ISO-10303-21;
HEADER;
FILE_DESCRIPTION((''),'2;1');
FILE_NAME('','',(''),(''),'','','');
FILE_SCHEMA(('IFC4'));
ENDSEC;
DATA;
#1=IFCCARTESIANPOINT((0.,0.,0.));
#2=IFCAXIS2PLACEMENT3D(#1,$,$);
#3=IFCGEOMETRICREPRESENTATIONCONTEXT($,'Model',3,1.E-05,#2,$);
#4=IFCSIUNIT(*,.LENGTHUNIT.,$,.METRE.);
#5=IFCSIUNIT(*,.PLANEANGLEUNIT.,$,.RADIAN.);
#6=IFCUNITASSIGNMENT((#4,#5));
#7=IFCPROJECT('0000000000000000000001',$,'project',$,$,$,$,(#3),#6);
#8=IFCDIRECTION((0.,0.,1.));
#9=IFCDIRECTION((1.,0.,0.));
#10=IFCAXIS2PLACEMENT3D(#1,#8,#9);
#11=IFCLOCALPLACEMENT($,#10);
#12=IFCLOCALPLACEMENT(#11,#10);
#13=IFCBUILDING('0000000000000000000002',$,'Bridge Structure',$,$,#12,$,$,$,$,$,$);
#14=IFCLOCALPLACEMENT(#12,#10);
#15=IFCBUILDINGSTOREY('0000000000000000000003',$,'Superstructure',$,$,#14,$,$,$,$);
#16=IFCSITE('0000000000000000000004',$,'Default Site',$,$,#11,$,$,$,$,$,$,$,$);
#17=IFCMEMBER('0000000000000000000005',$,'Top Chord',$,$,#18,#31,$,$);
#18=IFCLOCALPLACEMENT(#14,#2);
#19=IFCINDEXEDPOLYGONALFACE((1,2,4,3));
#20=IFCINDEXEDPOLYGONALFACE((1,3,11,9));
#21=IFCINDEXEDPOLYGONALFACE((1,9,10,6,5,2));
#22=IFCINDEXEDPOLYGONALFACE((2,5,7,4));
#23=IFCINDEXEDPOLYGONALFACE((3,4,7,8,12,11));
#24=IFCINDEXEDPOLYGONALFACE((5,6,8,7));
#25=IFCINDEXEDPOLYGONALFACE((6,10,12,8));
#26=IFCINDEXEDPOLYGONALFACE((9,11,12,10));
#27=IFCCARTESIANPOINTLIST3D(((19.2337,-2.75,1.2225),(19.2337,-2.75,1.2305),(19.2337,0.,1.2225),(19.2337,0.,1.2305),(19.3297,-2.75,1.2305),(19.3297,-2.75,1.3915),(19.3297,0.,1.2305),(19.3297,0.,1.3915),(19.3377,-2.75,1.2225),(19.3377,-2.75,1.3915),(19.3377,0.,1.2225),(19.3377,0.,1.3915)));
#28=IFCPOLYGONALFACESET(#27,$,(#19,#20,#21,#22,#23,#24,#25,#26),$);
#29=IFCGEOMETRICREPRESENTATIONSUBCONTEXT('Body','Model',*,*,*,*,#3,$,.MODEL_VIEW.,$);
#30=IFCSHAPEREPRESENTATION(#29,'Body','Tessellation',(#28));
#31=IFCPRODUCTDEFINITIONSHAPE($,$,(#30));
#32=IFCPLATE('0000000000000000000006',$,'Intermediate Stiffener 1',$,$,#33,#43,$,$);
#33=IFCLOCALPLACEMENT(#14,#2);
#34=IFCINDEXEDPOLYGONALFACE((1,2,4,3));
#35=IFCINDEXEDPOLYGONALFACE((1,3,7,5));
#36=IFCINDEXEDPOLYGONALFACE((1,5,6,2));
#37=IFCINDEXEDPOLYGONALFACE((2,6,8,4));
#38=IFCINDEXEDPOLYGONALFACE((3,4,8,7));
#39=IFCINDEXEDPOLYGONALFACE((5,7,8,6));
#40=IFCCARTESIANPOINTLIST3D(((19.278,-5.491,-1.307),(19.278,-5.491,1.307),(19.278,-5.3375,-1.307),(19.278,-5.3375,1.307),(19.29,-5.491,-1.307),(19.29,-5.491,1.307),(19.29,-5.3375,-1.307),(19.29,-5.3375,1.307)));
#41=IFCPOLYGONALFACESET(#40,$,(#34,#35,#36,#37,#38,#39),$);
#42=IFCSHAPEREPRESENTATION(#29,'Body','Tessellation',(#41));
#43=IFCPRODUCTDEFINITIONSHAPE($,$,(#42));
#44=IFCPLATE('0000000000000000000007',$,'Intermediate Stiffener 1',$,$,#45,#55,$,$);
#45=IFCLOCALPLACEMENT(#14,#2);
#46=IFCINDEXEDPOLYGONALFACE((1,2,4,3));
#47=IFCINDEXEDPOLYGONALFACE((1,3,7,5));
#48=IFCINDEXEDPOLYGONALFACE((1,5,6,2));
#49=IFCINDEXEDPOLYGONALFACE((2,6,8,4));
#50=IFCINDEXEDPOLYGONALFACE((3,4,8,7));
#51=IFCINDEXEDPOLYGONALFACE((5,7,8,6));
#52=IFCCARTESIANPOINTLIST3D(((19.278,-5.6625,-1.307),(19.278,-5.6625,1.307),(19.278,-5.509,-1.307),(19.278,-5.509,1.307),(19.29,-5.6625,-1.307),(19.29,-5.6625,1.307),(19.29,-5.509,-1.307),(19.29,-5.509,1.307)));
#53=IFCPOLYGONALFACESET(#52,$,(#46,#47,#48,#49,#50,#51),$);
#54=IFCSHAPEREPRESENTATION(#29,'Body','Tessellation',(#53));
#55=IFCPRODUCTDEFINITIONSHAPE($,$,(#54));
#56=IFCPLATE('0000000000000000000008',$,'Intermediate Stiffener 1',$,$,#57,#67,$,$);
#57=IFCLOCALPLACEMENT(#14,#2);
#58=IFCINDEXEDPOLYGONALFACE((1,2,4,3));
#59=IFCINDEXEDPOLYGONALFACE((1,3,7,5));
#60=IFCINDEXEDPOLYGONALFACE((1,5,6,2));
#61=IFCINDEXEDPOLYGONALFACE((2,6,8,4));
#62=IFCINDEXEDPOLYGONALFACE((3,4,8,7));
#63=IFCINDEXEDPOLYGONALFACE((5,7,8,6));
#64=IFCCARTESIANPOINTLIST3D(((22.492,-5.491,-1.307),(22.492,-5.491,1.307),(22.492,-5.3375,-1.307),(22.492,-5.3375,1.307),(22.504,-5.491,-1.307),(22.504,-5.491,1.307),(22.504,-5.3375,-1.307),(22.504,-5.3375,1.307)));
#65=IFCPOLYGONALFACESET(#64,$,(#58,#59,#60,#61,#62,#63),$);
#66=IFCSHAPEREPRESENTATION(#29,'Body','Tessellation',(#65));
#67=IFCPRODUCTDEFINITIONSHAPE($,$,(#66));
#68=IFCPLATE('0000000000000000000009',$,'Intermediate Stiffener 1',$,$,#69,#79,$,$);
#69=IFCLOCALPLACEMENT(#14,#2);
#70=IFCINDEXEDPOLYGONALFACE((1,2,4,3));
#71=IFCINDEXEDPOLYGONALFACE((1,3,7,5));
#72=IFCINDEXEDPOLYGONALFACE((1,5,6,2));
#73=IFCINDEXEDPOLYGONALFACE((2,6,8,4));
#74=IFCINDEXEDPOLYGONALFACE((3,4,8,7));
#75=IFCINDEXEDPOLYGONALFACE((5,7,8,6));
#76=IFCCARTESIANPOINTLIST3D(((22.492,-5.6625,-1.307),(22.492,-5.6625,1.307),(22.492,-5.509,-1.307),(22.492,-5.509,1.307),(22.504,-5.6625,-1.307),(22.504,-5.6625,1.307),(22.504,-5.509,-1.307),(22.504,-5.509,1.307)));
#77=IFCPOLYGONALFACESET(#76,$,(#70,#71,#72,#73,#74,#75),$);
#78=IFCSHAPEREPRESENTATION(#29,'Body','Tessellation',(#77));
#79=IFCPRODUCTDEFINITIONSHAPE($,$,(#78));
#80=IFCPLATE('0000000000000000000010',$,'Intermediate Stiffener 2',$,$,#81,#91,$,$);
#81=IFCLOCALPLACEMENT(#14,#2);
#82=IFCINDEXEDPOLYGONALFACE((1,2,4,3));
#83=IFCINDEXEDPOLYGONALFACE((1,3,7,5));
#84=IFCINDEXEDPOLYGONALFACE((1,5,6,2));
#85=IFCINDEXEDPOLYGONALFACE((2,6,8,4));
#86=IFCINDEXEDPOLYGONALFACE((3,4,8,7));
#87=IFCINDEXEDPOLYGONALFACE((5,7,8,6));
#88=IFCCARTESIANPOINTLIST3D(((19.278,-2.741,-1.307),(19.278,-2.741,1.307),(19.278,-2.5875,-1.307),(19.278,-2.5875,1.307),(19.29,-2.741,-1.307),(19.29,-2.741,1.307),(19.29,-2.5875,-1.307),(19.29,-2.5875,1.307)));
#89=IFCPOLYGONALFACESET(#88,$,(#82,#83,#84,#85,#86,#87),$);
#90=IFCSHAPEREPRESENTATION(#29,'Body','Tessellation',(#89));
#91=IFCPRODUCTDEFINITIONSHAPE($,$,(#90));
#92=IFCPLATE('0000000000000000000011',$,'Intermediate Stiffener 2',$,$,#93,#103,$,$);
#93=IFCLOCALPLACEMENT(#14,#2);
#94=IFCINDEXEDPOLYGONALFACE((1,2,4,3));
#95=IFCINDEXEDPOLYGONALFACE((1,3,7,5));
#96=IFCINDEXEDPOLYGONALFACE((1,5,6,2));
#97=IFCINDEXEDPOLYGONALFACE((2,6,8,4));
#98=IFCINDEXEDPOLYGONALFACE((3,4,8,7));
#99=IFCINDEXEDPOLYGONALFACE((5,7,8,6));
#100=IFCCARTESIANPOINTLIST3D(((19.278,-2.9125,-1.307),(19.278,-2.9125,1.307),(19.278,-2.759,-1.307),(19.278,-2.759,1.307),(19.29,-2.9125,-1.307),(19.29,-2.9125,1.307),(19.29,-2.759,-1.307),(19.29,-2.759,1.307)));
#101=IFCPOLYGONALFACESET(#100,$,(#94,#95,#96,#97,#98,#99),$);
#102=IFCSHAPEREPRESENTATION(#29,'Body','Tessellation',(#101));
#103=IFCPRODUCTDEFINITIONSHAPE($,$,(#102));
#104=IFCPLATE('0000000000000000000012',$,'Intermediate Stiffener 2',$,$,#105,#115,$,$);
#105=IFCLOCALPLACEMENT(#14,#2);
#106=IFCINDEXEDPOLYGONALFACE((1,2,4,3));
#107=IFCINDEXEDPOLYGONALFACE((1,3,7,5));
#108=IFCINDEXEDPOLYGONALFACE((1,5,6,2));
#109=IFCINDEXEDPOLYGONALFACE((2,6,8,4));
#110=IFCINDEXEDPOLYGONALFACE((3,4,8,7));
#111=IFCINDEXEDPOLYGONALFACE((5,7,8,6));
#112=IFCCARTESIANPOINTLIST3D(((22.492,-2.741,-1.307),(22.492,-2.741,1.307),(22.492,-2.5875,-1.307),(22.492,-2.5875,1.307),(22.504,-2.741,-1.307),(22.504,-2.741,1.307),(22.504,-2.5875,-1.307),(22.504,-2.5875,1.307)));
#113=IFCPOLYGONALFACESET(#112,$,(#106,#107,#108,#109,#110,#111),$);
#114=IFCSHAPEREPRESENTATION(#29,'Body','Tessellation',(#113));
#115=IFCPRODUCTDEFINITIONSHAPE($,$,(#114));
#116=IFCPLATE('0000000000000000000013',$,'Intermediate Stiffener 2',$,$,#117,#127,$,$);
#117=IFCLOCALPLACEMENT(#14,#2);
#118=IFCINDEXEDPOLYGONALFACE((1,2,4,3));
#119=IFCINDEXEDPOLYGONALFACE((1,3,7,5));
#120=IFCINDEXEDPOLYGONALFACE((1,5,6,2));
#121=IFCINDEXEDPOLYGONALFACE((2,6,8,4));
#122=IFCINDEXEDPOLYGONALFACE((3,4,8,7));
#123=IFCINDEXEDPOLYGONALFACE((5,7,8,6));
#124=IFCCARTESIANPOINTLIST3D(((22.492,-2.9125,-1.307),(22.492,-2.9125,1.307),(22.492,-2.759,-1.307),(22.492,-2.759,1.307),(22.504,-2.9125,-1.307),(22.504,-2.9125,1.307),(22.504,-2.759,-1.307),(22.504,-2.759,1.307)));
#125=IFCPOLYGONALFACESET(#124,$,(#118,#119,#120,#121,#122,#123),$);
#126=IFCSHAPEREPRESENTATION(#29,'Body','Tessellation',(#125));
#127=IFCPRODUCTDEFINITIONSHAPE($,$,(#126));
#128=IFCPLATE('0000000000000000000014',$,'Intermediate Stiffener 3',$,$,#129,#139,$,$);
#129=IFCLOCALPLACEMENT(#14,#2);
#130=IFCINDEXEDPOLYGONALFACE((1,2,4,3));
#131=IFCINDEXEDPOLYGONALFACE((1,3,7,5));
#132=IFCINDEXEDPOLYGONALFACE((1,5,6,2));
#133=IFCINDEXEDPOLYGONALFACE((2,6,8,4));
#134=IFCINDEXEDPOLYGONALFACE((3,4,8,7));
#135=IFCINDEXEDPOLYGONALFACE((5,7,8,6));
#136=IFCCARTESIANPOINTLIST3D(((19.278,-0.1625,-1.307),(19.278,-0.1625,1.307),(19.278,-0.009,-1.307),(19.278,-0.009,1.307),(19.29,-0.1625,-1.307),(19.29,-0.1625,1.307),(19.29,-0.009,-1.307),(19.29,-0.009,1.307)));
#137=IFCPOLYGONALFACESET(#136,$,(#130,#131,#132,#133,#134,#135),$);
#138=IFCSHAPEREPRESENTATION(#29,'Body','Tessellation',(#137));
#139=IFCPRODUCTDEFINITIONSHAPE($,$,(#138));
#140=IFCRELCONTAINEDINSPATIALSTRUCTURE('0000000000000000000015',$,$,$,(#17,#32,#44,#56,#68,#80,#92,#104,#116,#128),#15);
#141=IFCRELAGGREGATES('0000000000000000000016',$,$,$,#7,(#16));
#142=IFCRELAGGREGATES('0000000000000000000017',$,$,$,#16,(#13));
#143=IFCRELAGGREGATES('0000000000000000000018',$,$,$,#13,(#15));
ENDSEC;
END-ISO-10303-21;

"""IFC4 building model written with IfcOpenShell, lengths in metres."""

from ifc_helpers import new_model, si_unit, frame, origin, origin_with_axes, origin_2d_with_axis, place, context, subcontext, project, spatial, rectangle, l_section, extrude, element, save


model = new_model("IFC4")

# Units and contexts
model_context = context("Model", 3, precision=1e-05, world=origin())
body_context = subcontext(model_context, "Body", "Model", "MODEL_VIEW")
ifc_project = project(units=[si_unit("LENGTHUNIT", "METRE"), si_unit("PLANEANGLEUNIT", "RADIAN")], contexts=[model_context])

# Site, building, storey
site_placement = place(None, origin_with_axes())
site = spatial("IfcSite", under=ifc_project, at=site_placement, Name="Default Site")
building_placement = place(site_placement, origin_with_axes())
building = spatial("IfcBuilding", under=site, at=building_placement, Name="Bridge Structure")
storey_placement = place(building_placement, origin_with_axes())
storey = spatial("IfcBuildingStorey", under=building, at=storey_placement, Name="Superstructure")

# Member
for number, where, z_axis, x_axis, name in (
    (1, (19.2857, -2.75, 1.307), (0.0, 1.0, 0.0), (-1.0, 0.0, 0.0), "Top Chord"),
):
    element("IfcMember", number, at=place(storey_placement, frame(where, z_axis=z_axis, x_axis=x_axis)), inside=storey, Name=name, context=body_context, shape_type="SweptSolid", body=[
        extrude(l_section(Depth=0.169, Width=0.104, Thickness=0.008, at=origin_2d_with_axis()), origin_with_axes(), (0.0, 0.0, 1.0), 2.75),
    ])

# Plates
for number, where, z_axis, x_axis, name in (
    (2, (19.284, -5.4143, -1.307), (0.0, 0.0, 1.0), (1.0, 0.0, 0.0), "Intermediate Stiffener 1"),
    (3, (19.284, -5.5857, -1.307), (0.0, 0.0, 1.0), (1.0, 0.0, 0.0), "Intermediate Stiffener 1"),
    (4, (22.498, -5.4143, -1.307), (0.0, 0.0, 1.0), (1.0, 0.0, 0.0), "Intermediate Stiffener 1"),
    (5, (22.498, -5.5857, -1.307), (0.0, 0.0, 1.0), (1.0, 0.0, 0.0), "Intermediate Stiffener 1"),
    (6, (19.284, -2.6643, -1.307), (0.0, 0.0, 1.0), (1.0, 0.0, 0.0), "Intermediate Stiffener 2"),
    (7, (19.284, -2.8357, -1.307), (0.0, 0.0, 1.0), (1.0, 0.0, 0.0), "Intermediate Stiffener 2"),
    (8, (22.498, -2.6643, -1.307), (0.0, 0.0, 1.0), (1.0, 0.0, 0.0), "Intermediate Stiffener 2"),
    (9, (22.498, -2.8357, -1.307), (0.0, 0.0, 1.0), (1.0, 0.0, 0.0), "Intermediate Stiffener 2"),
    (10, (19.284, -0.0858, -1.307), (0.0, 0.0, 1.0), (1.0, 0.0, 0.0), "Intermediate Stiffener 3"),
):
    element("IfcPlate", number, at=place(storey_placement, frame(where, z_axis=z_axis, x_axis=x_axis)), inside=storey, Name=name, context=body_context, shape_type="SweptSolid", body=[
        extrude(rectangle(XDim=0.012, YDim=0.1535, at=origin_2d_with_axis()), origin_with_axes(), (0.0, 0.0, 1.0), 2.614),
    ])

save(model, "model.ifc")
